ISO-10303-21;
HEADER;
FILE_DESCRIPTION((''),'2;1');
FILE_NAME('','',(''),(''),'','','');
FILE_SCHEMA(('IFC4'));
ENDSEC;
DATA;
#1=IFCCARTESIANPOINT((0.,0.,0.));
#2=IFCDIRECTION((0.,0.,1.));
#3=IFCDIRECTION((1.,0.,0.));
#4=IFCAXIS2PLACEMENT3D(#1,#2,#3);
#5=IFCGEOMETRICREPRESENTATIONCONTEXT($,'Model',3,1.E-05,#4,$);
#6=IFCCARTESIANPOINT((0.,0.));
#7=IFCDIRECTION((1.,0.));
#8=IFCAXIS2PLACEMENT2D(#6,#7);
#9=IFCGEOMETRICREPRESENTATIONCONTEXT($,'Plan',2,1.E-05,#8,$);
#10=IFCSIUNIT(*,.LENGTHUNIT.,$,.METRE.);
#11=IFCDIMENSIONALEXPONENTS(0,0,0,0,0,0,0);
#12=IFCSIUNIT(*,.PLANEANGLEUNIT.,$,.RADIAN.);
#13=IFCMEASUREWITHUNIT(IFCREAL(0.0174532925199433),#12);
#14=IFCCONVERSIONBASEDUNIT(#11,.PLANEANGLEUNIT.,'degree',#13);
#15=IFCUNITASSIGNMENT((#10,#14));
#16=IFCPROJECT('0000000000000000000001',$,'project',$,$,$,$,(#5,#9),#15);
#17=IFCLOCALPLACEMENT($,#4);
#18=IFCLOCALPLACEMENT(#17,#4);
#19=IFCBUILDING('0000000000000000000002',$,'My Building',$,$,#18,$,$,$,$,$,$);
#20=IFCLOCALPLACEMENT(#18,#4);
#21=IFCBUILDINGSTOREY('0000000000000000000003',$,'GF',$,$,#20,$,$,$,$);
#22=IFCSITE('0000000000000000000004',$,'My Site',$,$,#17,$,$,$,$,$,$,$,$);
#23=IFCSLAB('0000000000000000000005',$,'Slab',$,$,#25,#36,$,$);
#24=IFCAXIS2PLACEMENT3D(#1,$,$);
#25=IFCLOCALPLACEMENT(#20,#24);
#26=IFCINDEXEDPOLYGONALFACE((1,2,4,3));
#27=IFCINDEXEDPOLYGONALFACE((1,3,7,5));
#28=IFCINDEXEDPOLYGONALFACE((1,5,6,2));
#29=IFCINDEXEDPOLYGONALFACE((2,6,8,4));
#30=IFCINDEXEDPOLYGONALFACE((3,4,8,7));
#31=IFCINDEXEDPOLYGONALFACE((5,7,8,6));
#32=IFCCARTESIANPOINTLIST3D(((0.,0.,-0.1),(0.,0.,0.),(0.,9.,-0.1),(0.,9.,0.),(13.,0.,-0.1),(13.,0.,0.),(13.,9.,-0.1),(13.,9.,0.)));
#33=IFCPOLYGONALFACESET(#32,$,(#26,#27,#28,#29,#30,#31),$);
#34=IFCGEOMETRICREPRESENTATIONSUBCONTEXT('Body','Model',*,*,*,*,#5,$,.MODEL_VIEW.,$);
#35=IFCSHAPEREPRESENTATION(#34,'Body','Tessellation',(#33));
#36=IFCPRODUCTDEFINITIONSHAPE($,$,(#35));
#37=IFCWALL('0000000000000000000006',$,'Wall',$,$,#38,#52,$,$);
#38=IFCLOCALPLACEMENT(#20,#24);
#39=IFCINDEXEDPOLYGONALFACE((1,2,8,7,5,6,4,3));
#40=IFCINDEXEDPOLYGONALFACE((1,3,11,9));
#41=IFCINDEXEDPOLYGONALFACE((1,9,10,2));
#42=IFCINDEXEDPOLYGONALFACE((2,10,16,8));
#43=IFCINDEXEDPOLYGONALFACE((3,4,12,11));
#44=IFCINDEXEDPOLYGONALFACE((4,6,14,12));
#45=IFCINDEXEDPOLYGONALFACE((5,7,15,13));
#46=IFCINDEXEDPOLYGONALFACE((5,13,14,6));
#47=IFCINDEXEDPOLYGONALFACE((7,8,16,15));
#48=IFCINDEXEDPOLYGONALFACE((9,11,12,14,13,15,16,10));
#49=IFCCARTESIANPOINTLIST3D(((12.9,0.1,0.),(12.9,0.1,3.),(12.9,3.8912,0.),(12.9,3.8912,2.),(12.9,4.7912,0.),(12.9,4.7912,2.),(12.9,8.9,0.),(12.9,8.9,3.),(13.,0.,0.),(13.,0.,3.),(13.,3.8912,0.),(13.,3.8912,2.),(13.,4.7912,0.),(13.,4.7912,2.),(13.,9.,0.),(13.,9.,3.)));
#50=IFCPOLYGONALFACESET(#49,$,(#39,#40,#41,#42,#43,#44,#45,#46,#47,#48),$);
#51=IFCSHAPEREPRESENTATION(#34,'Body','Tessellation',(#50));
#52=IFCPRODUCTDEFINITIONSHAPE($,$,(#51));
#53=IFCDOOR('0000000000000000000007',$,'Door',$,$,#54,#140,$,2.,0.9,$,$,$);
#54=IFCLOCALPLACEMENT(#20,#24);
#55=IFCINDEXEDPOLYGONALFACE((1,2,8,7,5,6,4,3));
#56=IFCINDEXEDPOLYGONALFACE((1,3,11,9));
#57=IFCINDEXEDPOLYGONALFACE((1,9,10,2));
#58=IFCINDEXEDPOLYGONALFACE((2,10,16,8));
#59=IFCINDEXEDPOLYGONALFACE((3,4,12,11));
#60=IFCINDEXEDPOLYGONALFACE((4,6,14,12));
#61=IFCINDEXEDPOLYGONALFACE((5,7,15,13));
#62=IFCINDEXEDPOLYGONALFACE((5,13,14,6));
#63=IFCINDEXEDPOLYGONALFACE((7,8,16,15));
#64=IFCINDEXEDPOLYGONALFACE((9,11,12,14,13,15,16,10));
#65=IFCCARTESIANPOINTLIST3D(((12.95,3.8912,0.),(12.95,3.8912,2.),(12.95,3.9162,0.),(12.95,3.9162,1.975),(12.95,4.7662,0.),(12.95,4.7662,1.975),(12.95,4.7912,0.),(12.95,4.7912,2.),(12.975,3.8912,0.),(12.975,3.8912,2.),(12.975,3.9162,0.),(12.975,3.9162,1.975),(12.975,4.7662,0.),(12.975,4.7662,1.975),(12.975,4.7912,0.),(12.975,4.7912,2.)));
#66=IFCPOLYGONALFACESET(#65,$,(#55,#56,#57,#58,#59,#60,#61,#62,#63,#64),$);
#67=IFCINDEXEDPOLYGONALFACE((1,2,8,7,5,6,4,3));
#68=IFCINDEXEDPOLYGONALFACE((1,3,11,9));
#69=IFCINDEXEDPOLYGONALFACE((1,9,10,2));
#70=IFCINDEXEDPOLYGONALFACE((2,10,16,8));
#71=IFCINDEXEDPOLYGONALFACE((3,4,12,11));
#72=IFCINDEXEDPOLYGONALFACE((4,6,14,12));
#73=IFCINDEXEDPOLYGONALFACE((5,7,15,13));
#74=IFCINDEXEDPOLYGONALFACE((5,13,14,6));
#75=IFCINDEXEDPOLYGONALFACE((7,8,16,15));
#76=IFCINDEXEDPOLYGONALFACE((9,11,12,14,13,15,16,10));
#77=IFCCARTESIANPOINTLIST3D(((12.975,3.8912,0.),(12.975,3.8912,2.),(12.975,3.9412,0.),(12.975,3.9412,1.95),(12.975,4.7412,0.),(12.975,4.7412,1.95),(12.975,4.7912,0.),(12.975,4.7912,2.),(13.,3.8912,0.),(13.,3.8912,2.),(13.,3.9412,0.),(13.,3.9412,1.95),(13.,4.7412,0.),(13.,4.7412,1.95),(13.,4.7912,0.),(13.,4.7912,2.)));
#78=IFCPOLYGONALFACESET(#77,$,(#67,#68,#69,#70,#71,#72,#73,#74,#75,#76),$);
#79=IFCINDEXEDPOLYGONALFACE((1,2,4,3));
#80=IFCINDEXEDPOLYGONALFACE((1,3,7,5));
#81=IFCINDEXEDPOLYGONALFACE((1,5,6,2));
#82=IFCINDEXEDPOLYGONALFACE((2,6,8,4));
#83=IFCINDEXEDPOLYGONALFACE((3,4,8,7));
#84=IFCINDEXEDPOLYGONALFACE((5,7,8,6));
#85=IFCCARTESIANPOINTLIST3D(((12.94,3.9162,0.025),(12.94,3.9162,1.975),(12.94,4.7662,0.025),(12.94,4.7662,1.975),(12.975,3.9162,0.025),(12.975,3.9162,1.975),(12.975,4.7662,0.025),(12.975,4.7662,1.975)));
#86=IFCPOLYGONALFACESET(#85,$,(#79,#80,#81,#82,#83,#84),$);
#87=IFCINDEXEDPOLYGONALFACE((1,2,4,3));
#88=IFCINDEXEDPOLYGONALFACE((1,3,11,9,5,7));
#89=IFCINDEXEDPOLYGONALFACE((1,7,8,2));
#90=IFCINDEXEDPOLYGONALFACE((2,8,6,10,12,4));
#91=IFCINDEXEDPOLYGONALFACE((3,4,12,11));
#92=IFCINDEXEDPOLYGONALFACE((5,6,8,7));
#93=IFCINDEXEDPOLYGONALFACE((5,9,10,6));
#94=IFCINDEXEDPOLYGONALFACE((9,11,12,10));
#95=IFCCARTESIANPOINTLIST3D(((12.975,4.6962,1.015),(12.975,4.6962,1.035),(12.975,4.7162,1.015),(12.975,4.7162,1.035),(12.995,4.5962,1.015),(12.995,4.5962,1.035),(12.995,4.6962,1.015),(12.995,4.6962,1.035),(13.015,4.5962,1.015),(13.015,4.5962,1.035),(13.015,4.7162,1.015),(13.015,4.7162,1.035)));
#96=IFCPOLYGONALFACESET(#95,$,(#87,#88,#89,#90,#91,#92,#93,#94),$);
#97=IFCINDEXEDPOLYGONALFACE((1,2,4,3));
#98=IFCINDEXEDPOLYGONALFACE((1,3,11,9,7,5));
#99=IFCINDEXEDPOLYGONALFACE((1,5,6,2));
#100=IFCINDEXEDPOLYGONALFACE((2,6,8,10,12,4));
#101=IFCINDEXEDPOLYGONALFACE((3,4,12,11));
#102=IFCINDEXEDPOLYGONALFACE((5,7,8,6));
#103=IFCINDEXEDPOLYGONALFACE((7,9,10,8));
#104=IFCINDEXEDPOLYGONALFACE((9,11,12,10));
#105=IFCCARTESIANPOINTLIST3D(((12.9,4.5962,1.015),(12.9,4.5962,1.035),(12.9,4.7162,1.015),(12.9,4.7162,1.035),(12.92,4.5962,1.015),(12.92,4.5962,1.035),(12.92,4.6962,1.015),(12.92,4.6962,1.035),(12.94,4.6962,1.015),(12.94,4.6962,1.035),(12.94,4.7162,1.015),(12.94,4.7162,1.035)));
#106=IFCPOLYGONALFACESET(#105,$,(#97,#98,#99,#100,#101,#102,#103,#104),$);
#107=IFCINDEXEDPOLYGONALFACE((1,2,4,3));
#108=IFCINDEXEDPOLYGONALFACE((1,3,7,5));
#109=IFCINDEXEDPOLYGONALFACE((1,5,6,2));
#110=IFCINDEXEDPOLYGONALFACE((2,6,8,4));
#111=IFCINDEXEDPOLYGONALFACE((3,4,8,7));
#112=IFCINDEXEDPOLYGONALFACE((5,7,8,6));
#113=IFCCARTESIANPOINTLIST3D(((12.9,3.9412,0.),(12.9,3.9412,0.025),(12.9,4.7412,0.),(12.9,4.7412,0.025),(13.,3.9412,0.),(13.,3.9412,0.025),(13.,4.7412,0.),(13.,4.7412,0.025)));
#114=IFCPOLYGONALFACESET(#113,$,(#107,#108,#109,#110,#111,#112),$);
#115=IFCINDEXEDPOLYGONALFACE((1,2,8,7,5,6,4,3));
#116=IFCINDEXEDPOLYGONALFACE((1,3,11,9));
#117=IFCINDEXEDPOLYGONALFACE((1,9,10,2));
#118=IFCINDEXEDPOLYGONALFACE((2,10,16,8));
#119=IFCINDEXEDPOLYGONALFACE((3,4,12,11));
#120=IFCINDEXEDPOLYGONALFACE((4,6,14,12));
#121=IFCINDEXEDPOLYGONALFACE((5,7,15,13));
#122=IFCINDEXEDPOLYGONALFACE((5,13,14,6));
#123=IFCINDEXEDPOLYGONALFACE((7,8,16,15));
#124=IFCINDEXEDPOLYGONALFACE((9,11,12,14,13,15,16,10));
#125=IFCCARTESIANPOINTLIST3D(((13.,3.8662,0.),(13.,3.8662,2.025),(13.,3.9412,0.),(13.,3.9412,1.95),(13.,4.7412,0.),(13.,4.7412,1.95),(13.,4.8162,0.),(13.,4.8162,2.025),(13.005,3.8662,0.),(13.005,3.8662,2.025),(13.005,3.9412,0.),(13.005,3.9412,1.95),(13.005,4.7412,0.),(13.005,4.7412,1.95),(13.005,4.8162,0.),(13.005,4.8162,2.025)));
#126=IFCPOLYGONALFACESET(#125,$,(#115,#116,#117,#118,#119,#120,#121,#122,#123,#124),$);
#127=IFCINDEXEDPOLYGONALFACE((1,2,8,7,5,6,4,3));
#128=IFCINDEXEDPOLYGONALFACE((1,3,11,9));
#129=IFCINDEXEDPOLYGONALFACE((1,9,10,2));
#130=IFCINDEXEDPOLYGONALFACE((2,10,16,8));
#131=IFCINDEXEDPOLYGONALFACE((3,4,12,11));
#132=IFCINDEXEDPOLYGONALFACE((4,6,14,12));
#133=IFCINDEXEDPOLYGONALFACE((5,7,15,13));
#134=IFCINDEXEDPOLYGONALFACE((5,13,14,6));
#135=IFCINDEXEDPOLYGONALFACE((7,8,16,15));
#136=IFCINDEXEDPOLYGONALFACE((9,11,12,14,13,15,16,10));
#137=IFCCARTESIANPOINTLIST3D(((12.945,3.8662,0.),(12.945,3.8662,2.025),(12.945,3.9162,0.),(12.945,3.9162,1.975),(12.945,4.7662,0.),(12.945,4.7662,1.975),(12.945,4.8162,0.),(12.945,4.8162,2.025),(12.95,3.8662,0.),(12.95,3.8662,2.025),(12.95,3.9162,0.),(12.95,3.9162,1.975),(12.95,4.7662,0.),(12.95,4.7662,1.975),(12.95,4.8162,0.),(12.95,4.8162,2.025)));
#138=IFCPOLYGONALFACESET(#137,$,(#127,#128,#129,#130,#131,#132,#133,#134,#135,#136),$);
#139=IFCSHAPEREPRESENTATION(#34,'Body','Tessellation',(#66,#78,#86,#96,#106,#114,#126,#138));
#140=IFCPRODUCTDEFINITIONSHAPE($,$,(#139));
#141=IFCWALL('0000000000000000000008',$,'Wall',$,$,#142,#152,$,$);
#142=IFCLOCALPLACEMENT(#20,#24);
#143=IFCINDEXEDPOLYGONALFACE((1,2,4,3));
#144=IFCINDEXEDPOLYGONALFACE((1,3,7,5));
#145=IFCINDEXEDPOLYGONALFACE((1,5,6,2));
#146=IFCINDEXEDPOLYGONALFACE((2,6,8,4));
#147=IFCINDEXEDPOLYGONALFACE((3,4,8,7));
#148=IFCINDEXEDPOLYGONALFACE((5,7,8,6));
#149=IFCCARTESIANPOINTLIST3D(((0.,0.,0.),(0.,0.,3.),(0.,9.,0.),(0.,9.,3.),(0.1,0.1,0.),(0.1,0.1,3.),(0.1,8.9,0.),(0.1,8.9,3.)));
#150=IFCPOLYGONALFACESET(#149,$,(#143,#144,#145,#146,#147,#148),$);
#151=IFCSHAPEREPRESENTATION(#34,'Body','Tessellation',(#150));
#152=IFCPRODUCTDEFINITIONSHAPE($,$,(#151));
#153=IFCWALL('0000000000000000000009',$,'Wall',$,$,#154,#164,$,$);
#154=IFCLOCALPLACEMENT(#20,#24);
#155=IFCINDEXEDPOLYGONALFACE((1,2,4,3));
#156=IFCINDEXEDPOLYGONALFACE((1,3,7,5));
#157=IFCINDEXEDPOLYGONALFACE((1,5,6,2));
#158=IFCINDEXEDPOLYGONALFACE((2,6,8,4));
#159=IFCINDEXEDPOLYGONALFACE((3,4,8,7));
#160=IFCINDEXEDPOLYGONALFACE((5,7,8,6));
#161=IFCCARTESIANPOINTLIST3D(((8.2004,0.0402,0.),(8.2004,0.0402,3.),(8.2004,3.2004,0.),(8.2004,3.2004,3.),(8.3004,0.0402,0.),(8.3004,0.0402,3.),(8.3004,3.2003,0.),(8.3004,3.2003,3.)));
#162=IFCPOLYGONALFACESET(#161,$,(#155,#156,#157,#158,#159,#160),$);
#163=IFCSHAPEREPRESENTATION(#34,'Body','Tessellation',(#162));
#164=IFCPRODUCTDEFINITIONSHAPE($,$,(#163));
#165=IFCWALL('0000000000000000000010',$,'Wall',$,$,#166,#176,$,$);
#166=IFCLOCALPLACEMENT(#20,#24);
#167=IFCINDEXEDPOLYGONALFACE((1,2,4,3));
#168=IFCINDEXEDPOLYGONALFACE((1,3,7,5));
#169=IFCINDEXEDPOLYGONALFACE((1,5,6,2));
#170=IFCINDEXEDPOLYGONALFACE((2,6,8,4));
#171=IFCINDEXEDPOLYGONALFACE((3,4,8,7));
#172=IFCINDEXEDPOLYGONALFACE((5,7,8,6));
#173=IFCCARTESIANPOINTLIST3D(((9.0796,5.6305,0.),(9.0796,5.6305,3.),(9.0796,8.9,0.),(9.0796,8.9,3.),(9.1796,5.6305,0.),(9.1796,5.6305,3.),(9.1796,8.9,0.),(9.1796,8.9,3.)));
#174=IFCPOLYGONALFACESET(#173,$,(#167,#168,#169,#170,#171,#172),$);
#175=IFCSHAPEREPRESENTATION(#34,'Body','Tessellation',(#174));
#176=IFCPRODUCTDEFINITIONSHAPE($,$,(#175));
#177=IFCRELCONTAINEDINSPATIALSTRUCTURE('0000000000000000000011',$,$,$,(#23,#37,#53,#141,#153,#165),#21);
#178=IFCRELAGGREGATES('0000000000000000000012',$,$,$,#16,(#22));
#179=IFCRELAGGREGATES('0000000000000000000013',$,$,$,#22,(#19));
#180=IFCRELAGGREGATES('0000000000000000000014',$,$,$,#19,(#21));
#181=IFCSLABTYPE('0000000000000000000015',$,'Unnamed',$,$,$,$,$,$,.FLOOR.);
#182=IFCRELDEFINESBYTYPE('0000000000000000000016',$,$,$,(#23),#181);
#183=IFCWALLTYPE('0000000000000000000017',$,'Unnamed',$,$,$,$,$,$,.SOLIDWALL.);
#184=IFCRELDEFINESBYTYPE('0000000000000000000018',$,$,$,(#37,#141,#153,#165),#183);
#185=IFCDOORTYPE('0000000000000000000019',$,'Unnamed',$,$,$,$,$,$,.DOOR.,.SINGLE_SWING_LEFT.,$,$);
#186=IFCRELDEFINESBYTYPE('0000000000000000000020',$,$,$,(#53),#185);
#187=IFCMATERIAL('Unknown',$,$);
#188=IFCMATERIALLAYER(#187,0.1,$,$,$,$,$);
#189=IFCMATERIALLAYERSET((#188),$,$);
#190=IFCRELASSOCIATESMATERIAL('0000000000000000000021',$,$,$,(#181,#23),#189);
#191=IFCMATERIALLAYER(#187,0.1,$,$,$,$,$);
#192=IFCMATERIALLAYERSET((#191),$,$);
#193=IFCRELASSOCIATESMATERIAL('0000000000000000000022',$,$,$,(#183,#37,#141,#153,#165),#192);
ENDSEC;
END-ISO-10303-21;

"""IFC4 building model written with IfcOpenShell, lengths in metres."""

from ifc_helpers import new_model, entity, si_unit, converted_unit, frame, origin_with_axes, origin_2d_with_axis, place, context, subcontext, project, spatial, line, indexed_curve, outline, extrude, shape, source, transform, mapped, material, layer, layer_set, layer_usage, type_object, type_shapes, element, fill, save


model = new_model("IFC4")

# Units and contexts
model_context = context("Model", 3, precision=1e-05, world=origin_with_axes())
plan_context = context("Plan", 2, precision=1e-05, world=origin_2d_with_axis())
body_context_1 = subcontext(model_context, "Body", "Model", "MODEL_VIEW")
body_context_2 = subcontext(plan_context, "Body", "Plan", "PLAN_VIEW")
ifc_project = project(units=[si_unit("LENGTHUNIT", "METRE"), converted_unit("PLANEANGLEUNIT", "degree", entity("IfcReal", 0.0174532925199433), si_unit("PLANEANGLEUNIT", "RADIAN"), dimensions=[0, 0, 0, 0, 0, 0, 0])], contexts=[model_context, plan_context])

# Site, building, storey
site_placement = place(None, origin_with_axes())
site = spatial("IfcSite", under=ifc_project, at=site_placement, Name="My Site")
building_placement = place(site_placement, origin_with_axes())
building = spatial("IfcBuilding", under=site, at=building_placement, Name="My Building")
storey_placement = place(building_placement, origin_with_axes())
storey = spatial("IfcBuildingStorey", under=building, at=storey_placement, Name="GF")

# Slab
ifc_material = material(Name="Unknown")
ifc_layer_1 = layer(ifc_material, 0.1)
ifc_layer_set_1 = layer_set([ifc_layer_1])
ifc_layer_usage_1 = layer_usage(ifc_layer_set_1, "AXIS3", "POSITIVE", -0.1)
slab_type = type_object("IfcSlabType", Name="Unnamed", PredefinedType="FLOOR", material=ifc_layer_set_1)
slab_placement = place(storey_placement, frame((0.0, 9.0, 0.0), z_axis=(0.0, 0.0, 1.0), x_axis=(1.0, 0.0, 0.0)))
element("IfcSlab", 1, at=slab_placement, inside=storey, type_object=slab_type, material=ifc_layer_usage_1, Name="Slab", context=body_context_1, shape_type="SweptSolid", body=[
    extrude(outline(indexed_curve([(0.0, -9.0), (13.0, -9.0), (13.0, 0.0), (0.0, 0.0), (0.0, -9.0)])), frame((0.0, 0.0, -0.1), z_axis=(0.0, 0.0, 1.0), x_axis=(1.0, 0.0, 0.0)), (0.0, 0.0, 1.0), 0.1),
])

# Shared definitions
ifc_layer_2 = layer(ifc_material, 0.1)
ifc_layer_set_2 = layer_set([ifc_layer_2])
wall_type = type_object("IfcWallType", Name="Unnamed", PredefinedType="SOLIDWALL", material=ifc_layer_set_2)
shared_shape_1 = source(origin_with_axes(), body_context_1, "Body", "SweptSolid", [
    extrude(outline(indexed_curve([(0.0, 0.0), (0.9, 0.0), (0.9, 2.0), (0.0, 2.0)], segments=[line(1, 2, 3, 4, 1)])), frame((0.0, -0.6, 0.0), z_axis=(0.0, -1.0, 0.0), x_axis=(1.0, 0.0, 0.0)), (0.0, 0.0, -1.0), 1.2),
])
door_type = type_object("IfcDoorType", Name="Unnamed", OperationType="SINGLE_SWING_LEFT", PredefinedType="DOOR")
shared_shape_2 = source(origin_with_axes(), body_context_1, "Body", "SweptSolid", [
    extrude(outline(indexed_curve([(0.0, 0.0), (0.0, 2.0), (0.9, 2.0), (0.9, 0.0), (0.875, 0.0), (0.875, 1.975), (0.025, 1.975), (0.025, 0.0)], segments=[line(1, 2, 3, 4, 5, 6, 7, 8, 1)])), frame((0.0, 0.025, 0.0), z_axis=(0.0, -1.0, 0.0), x_axis=(1.0, 0.0, 0.0)), (0.0, 0.0, -1.0), 0.025),
    extrude(outline(indexed_curve([(0.0, 0.0), (0.0, 2.0), (0.9, 2.0), (0.9, 0.0), (0.85, 0.0), (0.85, 1.95), (0.05, 1.95), (0.05, 0.0)], segments=[line(1, 2, 3, 4, 5, 6, 7, 8, 1)])), frame((0.0, 0.0, 0.0), z_axis=(0.0, -1.0, 0.0), x_axis=(1.0, 0.0, 0.0)), (0.0, 0.0, -1.0), 0.025),
    extrude(outline(indexed_curve([(0.0, 0.0), (0.85, 0.0), (0.85, 0.035), (0.0, 0.035)], segments=[line(1, 2, 3, 4, 1)])), frame((0.025, 0.025, 0.025), z_axis=(0.0, 0.0, 1.0), x_axis=(1.0, 0.0, 0.0)), (0.0, 0.0, 1.0), 1.95),
    extrude(outline(indexed_curve([(0.0, 0.0), (0.0, -0.04), (-0.12, -0.04), (-0.12, -0.02), (-0.02, -0.02), (-0.02, 0.0)], segments=[line(1, 2, 3, 4, 5, 6, 1)])), frame((0.825, 0.025, 1.015), z_axis=(0.0, 0.0, 1.0), x_axis=(1.0, 0.0, 0.0)), (0.0, 0.0, 1.0), 0.02),
    extrude(outline(indexed_curve([(0.0, 0.0), (0.0, 0.04), (-0.12, 0.04), (-0.12, 0.02), (-0.02, 0.02), (-0.02, 0.0)], segments=[line(1, 2, 3, 4, 5, 6, 1)])), frame((0.825, 0.06, 1.015), z_axis=(0.0, 0.0, 1.0), x_axis=(1.0, 0.0, 0.0)), (0.0, 0.0, 1.0), 0.02),
    extrude(outline(indexed_curve([(0.0, 0.0), (0.8, 0.0), (0.8, 0.1), (0.0, 0.1)], segments=[line(1, 2, 3, 4, 1)])), frame((0.05, 0.0, 0.0), z_axis=(0.0, 0.0, 1.0), x_axis=(1.0, 0.0, 0.0)), (0.0, 0.0, 1.0), 0.025),
    extrude(outline(indexed_curve([(0.0, 0.0), (0.0, 2.025), (0.95, 2.025), (0.95, 0.0), (0.875, 0.0), (0.875, 1.95), (0.075, 1.95), (0.075, 0.0)], segments=[line(1, 2, 3, 4, 5, 6, 7, 8, 1)])), frame((-0.025, -0.005, 0.0), z_axis=(0.0, -1.0, 0.0), x_axis=(1.0, 0.0, 0.0)), (0.0, 0.0, -1.0), 0.005),
    extrude(outline(indexed_curve([(0.0, 0.0), (0.0, 2.025), (0.95, 2.025), (0.95, 0.0), (0.9, 0.0), (0.9, 1.975), (0.05, 1.975), (0.05, 0.0)], segments=[line(1, 2, 3, 4, 5, 6, 7, 8, 1)])), frame((-0.025, 0.05, 0.0), z_axis=(0.0, -1.0, 0.0), x_axis=(1.0, 0.0, 0.0)), (0.0, 0.0, -1.0), 0.005),
])
shared_shape_3 = source(origin_with_axes(), body_context_2, "Body", "Curve2D", [
    entity("IfcIndexedPolyCurve", entity("IfcCartesianPointList2D", [[0.0, 0.0], [0.0, 0.05], [0.025, 0.05], [0.025, 0.025], [0.05, 0.025], [0.05, 0.0]]), [entity("IfcLineIndex", [1, 2, 3, 4, 5, 6, 1])]),
    entity("IfcIndexedPolyCurve", entity("IfcCartesianPointList2D", [[0.9, 0.0], [0.9, 0.05], [0.875, 0.05], [0.875, 0.025], [0.85, 0.025], [0.85, 0.0]]), [entity("IfcLineIndex", [1, 2, 3, 4, 5, 6, 1])]),
    entity("IfcTrimmedCurve", entity("IfcEllipse", entity("IfcAxis2Placement2D", entity("IfcCartesianPoint", [0.06, 0.05]), entity("IfcDirection", [1.0, 0.0])), 0.815, 0.85), [entity("IfcCartesianPoint", [0.875, 0.05])], [entity("IfcCartesianPoint", [0.06, 0.9])], True, "CARTESIAN"),
    entity("IfcIndexedPolyCurve", entity("IfcCartesianPointList2D", [[0.025, 0.05], [0.06, 0.05], [0.06, 0.9], [0.025, 0.9]]), [entity("IfcLineIndex", [1, 2, 3, 4, 1])]),
])
type_shapes(door_type, [shared_shape_2, shared_shape_3])

# Wall, opening, door
ifc_layer_usage_2 = layer_usage(ifc_layer_set_2, "AXIS2", "POSITIVE", 0.0)
wall_1_placement = place(storey_placement, frame((13.0, 0.0, 0.0), z_axis=(0.0, 0.0, 1.0), x_axis=(0.0, 1.0, 0.0)))
wall_1 = element("IfcWall", 2, at=wall_1_placement, inside=storey, type_object=wall_type, material=ifc_layer_usage_2, Name="Wall", context=body_context_1, shape_type="SweptSolid", body=[
    extrude(outline(indexed_curve([(0.0, 0.0), (0.1, 0.1), (8.9, 0.1), (9.0, 0.0)], segments=[line(1, 2, 3, 4, 1)])), origin_with_axes(), (0.0, 0.0, 1.0), 3.0),
])
opening_1_placement = place(wall_1_placement, frame((3.8912, 0.0, 0.0), z_axis=(0.0, 0.0, 1.0), x_axis=(1.0, 0.0, 0.0)))
opening_1 = element("IfcOpeningElement", 3, at=opening_1_placement, cuts=wall_1, PredefinedType="OPENING", context=body_context_1, shape_type="MappedRepresentation", body=[
    mapped(shared_shape_1, transform((0.0, 0.0, 0.0), x_axis=(1.0, 0.0, 0.0), y_axis=(0.0, 1.0, 0.0), z_axis=(0.0, 0.0, 1.0), scale=1.0)),
])
door_1_placement = place(opening_1_placement, frame((0.0, 0.0, 0.0), z_axis=(0.0, 0.0, 1.0), x_axis=(1.0, 0.0, 0.0)))
door_1 = element("IfcDoor", 4, at=door_1_placement, inside=storey, type_object=door_type, Name="Door", OverallHeight=2.0, OverallWidth=0.9, shapes=[
    shape(body_context_1, "Body", "MappedRepresentation", [mapped(shared_shape_2, transform((0.0, 0.0, 0.0), x_axis=(1.0, 0.0, 0.0), y_axis=(0.0, 1.0, 0.0), z_axis=(0.0, 0.0, 1.0), scale=1.0))]),
    shape(body_context_2, "Body", "MappedRepresentation", [mapped(shared_shape_3, transform((0.0, 0.0, 0.0), x_axis=(1.0, 0.0, 0.0), y_axis=(0.0, 1.0, 0.0), z_axis=(0.0, 0.0, 1.0), scale=1.0))]),
])
fill(opening_1, door_1)

# Wall
ifc_layer_usage_3 = layer_usage(ifc_layer_set_2, "AXIS2", "POSITIVE", 0.0)
wall_2_placement = place(storey_placement, frame((0.0, 9.0, 0.0), z_axis=(0.0, 0.0, 1.0), x_axis=(0.0, -1.0, 0.0)))
element("IfcWall", 5, at=wall_2_placement, inside=storey, type_object=wall_type, material=ifc_layer_usage_3, Name="Wall", context=body_context_1, shape_type="SweptSolid", body=[
    extrude(outline(indexed_curve([(0.0, 0.0), (0.1, 0.1), (8.9, 0.1), (9.0, 0.0)], segments=[line(1, 2, 3, 4, 1)])), origin_with_axes(), (0.0, 0.0, 1.0), 3.0),
])

# Walls
ifc_layer_usage_4 = layer_usage(ifc_layer_set_2, "AXIS2", "POSITIVE", 0.0)
wall_3_placement = place(storey_placement, frame((8.3004, 0.0402, 0.0), z_axis=(0.0, 0.0, 1.0), x_axis=(0.000013, 1.0, 0.0)))
element("IfcWall", 6, at=wall_3_placement, inside=storey, type_object=wall_type, material=ifc_layer_usage_4, Name="Wall", context=body_context_1, shape_type="SweptSolid", body=[
    extrude(outline(indexed_curve([(0.0, 0.0), (0.0, 0.1), (3.1602, 0.1), (3.1602, 0.0)], segments=[line(1, 2, 3, 4, 1)])), origin_with_axes(), (0.0, 0.0, 1.0), 3.0),
])
ifc_layer_usage_5 = layer_usage(ifc_layer_set_2, "AXIS2", "POSITIVE", 0.0)
wall_4_placement = place(storey_placement, frame((9.1796, 5.6305, 0.0), z_axis=(0.0, 0.0, 1.0), x_axis=(0.0, 1.0, 0.0)))
element("IfcWall", 7, at=wall_4_placement, inside=storey, type_object=wall_type, material=ifc_layer_usage_5, Name="Wall", context=body_context_1, shape_type="SweptSolid", body=[
    extrude(outline(indexed_curve([(0.0, 0.0), (0.0, 0.1), (3.2695, 0.1), (3.2695, 0.0)], segments=[line(1, 2, 3, 4, 1)])), origin_with_axes(), (0.0, 0.0, 1.0), 3.0),
])

save(model, "model.ifc")
